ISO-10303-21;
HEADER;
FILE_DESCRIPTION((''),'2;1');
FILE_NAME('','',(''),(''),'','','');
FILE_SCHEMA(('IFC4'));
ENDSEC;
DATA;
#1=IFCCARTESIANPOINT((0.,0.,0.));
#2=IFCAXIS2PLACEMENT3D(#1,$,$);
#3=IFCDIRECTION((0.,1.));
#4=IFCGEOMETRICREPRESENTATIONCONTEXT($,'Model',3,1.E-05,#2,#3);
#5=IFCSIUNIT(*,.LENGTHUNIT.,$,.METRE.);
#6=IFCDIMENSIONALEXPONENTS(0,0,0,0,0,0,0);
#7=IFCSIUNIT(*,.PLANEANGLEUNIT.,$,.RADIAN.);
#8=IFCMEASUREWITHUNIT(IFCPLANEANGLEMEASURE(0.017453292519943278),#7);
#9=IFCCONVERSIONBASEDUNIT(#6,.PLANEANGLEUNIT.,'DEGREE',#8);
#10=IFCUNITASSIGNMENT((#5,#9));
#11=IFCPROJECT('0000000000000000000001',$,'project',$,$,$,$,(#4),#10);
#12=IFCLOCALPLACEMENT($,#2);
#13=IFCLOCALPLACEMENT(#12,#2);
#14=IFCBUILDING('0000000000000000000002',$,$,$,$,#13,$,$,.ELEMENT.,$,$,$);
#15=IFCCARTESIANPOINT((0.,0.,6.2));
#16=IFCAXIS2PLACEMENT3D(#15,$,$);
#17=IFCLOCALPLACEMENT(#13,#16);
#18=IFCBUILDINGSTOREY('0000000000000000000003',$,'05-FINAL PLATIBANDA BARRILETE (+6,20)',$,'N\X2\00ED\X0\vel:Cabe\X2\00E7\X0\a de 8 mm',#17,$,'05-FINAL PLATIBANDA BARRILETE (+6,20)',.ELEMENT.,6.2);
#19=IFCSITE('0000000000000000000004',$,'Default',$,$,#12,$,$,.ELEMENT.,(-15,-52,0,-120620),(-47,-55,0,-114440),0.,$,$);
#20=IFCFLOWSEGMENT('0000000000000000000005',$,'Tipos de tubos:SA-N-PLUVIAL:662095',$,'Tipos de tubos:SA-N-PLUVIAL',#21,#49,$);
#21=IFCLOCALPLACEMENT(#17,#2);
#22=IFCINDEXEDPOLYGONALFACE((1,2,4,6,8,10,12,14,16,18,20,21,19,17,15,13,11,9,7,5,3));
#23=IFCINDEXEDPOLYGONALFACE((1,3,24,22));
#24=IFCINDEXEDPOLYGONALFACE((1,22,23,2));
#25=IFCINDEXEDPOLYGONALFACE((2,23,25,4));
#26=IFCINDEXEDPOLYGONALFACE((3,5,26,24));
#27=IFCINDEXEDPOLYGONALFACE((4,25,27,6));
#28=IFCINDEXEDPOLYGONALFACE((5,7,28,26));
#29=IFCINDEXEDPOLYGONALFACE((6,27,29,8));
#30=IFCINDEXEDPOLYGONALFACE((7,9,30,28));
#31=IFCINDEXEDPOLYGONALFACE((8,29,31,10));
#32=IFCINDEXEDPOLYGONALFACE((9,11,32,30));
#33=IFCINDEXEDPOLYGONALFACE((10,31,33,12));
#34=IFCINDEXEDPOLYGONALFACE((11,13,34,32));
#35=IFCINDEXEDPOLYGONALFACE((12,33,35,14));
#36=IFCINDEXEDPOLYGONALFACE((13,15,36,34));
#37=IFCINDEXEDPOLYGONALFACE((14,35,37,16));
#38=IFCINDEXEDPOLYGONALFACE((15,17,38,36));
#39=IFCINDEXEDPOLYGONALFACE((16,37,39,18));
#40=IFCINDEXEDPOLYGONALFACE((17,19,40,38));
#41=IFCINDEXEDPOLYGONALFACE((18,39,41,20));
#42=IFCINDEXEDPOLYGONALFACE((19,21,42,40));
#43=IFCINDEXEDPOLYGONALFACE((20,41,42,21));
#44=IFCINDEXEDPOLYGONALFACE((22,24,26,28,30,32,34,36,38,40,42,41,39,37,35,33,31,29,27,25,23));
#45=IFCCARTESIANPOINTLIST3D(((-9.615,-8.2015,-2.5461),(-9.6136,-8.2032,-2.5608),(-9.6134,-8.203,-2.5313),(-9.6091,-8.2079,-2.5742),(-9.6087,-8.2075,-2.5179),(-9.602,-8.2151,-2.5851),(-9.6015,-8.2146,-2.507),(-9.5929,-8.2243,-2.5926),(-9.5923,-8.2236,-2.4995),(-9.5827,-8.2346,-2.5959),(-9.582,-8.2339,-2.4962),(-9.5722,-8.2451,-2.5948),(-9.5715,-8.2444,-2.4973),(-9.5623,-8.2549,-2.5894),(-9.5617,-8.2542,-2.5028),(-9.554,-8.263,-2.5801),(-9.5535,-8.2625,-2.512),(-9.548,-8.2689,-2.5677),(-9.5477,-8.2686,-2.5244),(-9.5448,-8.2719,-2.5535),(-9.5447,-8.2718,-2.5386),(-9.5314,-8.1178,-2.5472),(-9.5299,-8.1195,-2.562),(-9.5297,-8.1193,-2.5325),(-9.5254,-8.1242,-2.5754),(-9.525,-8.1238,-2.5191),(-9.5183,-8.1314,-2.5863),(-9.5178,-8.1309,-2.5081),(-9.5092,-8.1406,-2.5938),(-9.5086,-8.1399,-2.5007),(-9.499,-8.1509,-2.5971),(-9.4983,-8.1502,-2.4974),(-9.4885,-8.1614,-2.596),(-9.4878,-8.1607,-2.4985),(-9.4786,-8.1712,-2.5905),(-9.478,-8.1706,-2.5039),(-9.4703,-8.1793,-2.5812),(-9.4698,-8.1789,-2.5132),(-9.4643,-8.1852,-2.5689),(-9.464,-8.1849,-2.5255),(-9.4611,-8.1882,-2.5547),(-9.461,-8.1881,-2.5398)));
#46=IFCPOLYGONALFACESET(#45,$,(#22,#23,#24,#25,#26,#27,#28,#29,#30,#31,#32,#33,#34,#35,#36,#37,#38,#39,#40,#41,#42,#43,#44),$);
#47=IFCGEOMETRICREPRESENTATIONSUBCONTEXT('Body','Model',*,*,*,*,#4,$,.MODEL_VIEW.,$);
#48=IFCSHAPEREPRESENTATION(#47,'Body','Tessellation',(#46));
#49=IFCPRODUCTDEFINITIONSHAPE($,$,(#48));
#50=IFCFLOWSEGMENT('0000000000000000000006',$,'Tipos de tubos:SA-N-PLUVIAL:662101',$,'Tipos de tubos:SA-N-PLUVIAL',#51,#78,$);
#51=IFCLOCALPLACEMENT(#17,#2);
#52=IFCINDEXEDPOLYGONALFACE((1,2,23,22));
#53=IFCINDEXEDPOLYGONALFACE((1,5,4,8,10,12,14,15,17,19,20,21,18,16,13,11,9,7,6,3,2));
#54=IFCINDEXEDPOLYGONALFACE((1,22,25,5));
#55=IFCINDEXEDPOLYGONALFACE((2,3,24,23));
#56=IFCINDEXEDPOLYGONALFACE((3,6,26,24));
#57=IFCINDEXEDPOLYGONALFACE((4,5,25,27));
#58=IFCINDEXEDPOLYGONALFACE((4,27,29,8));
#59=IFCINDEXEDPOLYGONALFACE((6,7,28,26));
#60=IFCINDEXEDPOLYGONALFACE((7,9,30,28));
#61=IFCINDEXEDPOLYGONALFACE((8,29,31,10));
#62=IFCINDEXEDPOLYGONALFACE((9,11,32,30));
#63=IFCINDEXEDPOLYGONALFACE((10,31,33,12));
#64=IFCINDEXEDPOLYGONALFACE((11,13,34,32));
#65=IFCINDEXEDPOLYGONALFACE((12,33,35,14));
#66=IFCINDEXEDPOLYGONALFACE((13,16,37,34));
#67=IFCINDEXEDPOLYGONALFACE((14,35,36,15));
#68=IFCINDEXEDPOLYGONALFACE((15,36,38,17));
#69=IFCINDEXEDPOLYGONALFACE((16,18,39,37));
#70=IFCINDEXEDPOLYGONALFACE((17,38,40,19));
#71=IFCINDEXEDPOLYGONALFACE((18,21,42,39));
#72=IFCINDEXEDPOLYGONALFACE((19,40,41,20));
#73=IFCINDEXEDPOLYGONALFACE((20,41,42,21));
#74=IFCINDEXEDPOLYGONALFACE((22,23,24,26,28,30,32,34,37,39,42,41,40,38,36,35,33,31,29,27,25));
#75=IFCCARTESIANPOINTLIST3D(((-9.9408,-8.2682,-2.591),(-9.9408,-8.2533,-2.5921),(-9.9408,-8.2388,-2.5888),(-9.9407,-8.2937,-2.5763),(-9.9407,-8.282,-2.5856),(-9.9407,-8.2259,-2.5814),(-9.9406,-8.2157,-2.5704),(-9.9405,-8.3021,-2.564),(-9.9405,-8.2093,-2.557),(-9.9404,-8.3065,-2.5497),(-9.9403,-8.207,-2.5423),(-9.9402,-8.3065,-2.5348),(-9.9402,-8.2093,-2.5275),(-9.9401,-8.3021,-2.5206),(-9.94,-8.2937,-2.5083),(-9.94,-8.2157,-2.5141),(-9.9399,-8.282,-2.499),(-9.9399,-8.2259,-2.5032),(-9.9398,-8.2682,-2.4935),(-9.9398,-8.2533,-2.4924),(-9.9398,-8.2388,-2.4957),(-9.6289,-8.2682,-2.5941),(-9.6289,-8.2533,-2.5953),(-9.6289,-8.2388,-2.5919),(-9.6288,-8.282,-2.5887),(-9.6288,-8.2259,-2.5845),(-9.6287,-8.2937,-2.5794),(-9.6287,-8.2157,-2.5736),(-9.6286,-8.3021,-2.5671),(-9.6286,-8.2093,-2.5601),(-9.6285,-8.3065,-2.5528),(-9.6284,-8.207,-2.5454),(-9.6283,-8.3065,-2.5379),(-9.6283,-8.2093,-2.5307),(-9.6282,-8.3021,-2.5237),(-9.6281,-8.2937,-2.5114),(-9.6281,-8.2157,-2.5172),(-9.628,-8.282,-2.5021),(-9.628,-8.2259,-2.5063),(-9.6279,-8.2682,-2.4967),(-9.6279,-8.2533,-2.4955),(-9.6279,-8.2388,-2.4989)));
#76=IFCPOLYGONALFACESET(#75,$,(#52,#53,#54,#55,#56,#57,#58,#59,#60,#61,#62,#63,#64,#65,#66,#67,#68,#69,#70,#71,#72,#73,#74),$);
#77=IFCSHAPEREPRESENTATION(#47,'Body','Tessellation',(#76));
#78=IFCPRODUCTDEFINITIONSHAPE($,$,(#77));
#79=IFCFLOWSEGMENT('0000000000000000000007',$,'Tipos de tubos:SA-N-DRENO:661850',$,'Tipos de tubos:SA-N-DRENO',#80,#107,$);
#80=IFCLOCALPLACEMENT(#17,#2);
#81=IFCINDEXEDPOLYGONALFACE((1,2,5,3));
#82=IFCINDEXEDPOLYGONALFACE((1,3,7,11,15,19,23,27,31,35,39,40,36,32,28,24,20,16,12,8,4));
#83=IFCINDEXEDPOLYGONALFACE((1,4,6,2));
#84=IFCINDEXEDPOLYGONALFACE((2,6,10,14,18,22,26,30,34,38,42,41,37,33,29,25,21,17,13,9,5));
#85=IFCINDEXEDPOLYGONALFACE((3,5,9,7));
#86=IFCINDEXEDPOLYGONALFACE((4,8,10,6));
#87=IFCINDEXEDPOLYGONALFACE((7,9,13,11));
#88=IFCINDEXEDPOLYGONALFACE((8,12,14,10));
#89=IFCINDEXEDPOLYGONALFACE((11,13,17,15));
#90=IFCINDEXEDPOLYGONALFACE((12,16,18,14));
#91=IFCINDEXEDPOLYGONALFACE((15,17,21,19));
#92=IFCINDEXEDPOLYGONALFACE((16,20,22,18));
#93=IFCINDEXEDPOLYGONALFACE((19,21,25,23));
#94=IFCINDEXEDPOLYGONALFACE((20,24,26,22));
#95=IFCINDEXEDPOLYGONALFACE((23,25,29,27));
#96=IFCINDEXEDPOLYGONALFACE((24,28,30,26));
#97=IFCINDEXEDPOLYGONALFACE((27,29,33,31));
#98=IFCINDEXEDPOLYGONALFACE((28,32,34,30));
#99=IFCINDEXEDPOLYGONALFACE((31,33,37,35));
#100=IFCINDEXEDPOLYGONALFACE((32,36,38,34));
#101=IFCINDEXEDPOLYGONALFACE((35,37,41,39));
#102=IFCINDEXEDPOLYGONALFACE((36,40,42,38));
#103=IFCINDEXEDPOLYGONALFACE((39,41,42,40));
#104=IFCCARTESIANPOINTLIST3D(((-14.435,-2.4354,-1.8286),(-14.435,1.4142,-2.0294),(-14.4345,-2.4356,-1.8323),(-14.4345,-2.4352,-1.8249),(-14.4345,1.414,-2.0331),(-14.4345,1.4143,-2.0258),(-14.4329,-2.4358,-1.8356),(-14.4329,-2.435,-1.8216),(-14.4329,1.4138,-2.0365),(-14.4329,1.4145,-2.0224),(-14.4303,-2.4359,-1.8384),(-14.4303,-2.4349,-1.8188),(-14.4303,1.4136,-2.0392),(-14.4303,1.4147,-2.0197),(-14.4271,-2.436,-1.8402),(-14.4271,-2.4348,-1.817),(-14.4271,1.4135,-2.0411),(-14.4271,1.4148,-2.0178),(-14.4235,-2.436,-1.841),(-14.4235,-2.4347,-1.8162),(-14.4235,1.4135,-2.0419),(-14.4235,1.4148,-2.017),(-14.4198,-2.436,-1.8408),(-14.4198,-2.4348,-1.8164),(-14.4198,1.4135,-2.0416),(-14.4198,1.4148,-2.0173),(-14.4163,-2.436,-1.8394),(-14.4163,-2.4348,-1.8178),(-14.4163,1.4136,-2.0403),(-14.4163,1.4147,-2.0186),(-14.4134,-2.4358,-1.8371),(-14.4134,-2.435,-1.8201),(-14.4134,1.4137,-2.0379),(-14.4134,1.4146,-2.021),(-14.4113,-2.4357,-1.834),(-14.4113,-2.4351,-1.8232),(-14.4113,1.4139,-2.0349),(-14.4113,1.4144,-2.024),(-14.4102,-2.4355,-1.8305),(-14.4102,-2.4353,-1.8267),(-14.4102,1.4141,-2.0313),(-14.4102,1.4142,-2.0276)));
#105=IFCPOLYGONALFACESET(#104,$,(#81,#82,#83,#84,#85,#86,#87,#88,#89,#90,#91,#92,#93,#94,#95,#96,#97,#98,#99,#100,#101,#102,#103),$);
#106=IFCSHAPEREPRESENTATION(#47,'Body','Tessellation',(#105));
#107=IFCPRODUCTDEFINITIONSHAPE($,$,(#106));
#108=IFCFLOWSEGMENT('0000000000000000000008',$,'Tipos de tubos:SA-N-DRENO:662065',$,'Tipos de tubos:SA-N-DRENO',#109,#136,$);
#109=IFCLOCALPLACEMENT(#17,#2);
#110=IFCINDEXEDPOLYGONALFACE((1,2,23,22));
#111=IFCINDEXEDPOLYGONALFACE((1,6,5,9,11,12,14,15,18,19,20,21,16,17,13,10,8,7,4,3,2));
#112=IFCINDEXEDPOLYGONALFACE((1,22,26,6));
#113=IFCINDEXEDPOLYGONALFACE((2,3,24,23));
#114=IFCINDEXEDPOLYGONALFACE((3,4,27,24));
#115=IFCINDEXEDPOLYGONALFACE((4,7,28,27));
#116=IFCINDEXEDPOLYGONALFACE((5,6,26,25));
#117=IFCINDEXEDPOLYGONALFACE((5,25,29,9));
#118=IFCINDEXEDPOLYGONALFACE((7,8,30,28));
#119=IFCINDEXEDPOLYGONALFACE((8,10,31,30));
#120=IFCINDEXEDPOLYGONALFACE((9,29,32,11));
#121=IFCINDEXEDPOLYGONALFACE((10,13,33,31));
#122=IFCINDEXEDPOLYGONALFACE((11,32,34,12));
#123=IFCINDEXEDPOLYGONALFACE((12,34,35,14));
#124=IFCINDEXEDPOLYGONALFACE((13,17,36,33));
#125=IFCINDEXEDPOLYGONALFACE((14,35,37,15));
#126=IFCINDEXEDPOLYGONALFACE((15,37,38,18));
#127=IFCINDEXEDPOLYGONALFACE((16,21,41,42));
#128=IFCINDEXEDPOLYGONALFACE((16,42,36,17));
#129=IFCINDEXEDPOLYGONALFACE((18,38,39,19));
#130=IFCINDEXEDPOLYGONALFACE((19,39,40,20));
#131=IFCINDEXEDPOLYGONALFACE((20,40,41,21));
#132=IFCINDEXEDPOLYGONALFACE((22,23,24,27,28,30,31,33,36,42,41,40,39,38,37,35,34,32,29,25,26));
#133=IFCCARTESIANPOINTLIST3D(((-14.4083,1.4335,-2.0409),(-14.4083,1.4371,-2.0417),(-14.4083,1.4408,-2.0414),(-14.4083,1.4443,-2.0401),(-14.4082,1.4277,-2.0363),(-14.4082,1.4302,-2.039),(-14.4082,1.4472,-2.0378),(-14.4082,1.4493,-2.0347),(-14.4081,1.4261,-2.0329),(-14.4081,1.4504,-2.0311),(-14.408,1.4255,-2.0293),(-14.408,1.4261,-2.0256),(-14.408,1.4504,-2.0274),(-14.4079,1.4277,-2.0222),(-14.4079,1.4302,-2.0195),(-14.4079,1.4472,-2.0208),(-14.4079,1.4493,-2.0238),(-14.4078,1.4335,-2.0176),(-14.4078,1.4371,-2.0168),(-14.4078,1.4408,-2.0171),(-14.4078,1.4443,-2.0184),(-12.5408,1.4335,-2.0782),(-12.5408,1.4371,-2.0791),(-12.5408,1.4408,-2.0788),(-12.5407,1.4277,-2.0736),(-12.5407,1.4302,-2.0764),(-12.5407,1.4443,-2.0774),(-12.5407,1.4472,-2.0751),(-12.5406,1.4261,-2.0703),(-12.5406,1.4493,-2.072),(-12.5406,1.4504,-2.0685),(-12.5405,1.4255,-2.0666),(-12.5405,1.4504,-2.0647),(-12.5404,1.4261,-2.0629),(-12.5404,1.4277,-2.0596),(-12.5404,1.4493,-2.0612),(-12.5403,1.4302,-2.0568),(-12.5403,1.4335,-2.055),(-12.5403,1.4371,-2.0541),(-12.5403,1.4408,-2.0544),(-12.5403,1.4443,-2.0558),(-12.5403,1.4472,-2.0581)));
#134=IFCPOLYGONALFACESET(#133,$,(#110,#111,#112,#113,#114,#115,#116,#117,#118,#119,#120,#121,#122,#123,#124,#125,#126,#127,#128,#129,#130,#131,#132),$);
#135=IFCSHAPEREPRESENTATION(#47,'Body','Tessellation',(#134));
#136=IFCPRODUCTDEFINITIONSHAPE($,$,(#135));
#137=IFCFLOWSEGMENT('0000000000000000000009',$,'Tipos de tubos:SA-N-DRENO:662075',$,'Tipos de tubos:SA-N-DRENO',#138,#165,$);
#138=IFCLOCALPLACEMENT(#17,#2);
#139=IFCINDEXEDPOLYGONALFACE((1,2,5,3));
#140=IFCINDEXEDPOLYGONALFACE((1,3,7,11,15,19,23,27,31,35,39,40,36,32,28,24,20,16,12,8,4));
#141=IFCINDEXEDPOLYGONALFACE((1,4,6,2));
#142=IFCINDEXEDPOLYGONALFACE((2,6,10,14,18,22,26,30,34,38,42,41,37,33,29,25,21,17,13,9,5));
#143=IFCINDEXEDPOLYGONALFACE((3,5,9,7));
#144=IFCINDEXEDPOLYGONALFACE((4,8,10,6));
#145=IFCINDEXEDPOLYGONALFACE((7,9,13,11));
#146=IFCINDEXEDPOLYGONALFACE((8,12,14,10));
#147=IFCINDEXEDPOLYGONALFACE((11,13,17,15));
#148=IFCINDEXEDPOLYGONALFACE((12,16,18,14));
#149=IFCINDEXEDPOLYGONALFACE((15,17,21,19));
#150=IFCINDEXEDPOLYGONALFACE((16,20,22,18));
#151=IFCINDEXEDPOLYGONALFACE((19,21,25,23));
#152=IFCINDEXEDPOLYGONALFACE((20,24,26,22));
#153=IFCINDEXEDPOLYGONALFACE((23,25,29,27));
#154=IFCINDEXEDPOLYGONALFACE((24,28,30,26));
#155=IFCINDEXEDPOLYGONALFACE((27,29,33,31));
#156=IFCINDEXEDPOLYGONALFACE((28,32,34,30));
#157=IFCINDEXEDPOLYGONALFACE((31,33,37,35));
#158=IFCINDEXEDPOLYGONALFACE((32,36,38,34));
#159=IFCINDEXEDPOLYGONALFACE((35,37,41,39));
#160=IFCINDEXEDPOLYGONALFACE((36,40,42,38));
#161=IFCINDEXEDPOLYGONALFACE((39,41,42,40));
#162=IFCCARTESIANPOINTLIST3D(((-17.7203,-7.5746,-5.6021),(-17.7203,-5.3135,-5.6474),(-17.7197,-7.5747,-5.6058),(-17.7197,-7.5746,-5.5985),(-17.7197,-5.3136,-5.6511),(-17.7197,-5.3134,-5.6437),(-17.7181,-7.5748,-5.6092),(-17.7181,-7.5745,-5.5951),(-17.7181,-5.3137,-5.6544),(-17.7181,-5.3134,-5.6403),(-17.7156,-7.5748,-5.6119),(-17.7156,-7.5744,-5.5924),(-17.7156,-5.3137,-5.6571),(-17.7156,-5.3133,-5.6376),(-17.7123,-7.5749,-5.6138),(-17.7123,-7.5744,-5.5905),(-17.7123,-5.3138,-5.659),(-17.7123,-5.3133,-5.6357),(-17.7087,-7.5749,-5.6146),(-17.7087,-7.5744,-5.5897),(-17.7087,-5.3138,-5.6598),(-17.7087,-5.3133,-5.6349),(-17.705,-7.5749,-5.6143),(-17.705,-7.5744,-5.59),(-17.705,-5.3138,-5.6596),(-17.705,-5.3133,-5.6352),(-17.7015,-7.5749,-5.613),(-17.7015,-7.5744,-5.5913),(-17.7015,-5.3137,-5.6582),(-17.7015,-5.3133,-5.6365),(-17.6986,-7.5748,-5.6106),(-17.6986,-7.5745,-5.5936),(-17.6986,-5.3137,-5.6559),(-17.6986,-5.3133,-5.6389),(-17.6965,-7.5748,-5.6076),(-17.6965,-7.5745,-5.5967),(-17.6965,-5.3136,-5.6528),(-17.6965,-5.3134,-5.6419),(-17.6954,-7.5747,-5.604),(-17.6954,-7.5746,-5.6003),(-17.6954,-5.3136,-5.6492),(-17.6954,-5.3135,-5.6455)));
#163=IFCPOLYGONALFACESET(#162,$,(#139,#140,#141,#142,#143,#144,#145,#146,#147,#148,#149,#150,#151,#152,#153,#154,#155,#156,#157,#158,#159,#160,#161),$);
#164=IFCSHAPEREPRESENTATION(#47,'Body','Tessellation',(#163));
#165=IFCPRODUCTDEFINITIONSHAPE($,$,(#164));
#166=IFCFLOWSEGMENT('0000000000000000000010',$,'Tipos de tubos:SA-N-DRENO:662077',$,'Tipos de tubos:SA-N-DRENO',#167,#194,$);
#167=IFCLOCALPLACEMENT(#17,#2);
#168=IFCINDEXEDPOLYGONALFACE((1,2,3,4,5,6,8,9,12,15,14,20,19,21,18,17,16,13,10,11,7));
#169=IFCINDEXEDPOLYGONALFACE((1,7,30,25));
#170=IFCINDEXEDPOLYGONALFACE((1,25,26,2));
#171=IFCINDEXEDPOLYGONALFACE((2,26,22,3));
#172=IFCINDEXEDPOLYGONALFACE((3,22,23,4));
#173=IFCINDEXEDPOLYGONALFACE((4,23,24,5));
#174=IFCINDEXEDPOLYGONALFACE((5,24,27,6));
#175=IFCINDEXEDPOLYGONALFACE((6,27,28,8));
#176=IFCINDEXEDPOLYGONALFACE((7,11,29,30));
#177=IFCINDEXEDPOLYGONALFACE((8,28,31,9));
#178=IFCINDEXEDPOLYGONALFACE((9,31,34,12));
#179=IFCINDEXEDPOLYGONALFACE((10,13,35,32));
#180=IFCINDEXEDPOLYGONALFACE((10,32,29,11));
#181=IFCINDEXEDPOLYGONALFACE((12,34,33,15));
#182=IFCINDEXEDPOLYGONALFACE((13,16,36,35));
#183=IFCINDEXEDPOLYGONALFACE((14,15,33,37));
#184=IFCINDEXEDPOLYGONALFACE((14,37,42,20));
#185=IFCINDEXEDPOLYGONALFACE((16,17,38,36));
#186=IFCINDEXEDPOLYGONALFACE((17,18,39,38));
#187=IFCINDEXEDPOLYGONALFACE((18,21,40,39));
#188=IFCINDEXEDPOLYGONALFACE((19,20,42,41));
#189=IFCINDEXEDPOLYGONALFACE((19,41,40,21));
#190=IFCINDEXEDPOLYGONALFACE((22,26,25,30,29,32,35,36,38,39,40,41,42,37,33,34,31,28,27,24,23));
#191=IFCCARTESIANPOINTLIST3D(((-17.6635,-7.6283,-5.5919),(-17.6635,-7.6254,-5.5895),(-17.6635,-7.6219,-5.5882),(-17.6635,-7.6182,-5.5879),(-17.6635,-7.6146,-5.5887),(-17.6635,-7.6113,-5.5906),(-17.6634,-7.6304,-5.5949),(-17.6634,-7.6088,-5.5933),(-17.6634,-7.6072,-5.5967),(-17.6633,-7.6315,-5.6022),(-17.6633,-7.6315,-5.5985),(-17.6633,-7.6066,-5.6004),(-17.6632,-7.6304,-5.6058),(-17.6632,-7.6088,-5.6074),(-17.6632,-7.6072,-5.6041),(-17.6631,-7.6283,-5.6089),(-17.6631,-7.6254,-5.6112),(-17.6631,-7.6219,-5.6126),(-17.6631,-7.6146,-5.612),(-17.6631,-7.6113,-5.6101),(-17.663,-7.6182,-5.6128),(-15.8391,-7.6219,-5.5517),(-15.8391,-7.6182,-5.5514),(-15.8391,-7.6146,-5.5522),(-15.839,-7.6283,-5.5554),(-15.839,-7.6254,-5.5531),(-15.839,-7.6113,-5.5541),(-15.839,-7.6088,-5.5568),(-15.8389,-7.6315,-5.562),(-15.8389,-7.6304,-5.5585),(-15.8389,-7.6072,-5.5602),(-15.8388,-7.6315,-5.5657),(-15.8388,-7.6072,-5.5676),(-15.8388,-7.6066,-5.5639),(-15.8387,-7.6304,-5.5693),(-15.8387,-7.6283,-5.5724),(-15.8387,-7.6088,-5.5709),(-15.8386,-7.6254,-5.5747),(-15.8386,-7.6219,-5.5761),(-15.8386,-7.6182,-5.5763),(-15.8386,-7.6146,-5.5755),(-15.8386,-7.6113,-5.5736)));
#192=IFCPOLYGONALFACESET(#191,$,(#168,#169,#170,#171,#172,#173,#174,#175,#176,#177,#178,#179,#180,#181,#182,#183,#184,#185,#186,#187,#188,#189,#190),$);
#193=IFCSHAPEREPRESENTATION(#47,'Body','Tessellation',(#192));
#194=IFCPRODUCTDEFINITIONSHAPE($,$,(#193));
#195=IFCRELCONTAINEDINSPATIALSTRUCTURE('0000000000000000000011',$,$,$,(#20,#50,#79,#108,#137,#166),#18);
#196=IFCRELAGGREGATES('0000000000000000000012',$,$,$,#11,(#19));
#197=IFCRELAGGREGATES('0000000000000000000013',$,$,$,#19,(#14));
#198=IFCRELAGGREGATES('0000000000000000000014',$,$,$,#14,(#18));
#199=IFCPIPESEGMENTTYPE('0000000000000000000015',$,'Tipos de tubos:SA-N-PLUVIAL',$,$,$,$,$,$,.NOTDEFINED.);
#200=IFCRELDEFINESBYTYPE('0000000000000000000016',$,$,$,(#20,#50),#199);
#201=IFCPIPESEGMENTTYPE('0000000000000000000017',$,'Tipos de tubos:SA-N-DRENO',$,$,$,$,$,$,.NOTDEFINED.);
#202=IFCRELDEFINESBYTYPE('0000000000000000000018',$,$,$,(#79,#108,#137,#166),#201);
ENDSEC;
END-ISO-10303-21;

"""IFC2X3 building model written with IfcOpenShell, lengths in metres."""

from ifc_helpers import new_model, entity, si_unit, converted_unit, direction, frame, origin, origin_2d_with_axis, place, context, subcontext, project, spatial, circle, extrude, type_object, element, save


model = new_model("IFC2X3")

# Units and contexts
model_context = context("Model", 3, precision=1e-05, world=origin(), true_north=direction((0.0, 1.0)))
body_context = subcontext(model_context, "Body", "Model", "MODEL_VIEW")
ifc_project = project(units=[si_unit("LENGTHUNIT", "METRE"), converted_unit("PLANEANGLEUNIT", "DEGREE", entity("IfcPlaneAngleMeasure", 0.017453292519943278), si_unit("PLANEANGLEUNIT", "RADIAN"), dimensions=[0, 0, 0, 0, 0, 0, 0])], contexts=[model_context])

# Site, building, storey
site_placement = place(None, origin())
site = spatial("IfcSite", under=ifc_project, at=site_placement, Name="Default", CompositionType="ELEMENT", RefLatitude=(-15, -52, 0, -120620), RefLongitude=(-47, -55, 0, -114440), RefElevation=0.0)
building_placement = place(site_placement, origin())
building = spatial("IfcBuilding", under=site, at=building_placement, CompositionType="ELEMENT")
storey_placement = place(building_placement, frame((0.0, 0.0, 6.2)))
storey = spatial("IfcBuildingStorey", under=building, at=storey_placement, Name="05-FINAL PLATIBANDA BARRILETE (+6,20)", ObjectType="Nível:Cabeça de 8 mm", LongName="05-FINAL PLATIBANDA BARRILETE (+6,20)", CompositionType="ELEMENT", Elevation=6.2)

# Flow segments
pipe_segment_type_1 = type_object("IfcPipeSegmentType", Name="Tipos de tubos:SA-N-PLUVIAL", PredefinedType="NOTDEFINED")
flow_segment_1_placement = place(storey_placement, origin())
element("IfcFlowSegment", 1, at=flow_segment_1_placement, inside=storey, type_object=pipe_segment_type_1, Name="Tipos de tubos:SA-N-PLUVIAL:662095", ObjectType="Tipos de tubos:SA-N-PLUVIAL", context=body_context, shape_type="SweptSolid", body=[
    extrude(circle(Radius=0.05, at=origin_2d_with_axis()), frame((-9.5797, -8.2369, -2.5461), z_axis=(0.707071, 0.707072, -0.01), x_axis=(-0.707107, 0.707106, 0.0)), (0.0, 0.0, 1.0), 0.1184),
])
flow_segment_2_placement = place(storey_placement, origin())
element("IfcFlowSegment", 2, at=flow_segment_2_placement, inside=storey, type_object=pipe_segment_type_1, Name="Tipos de tubos:SA-N-PLUVIAL:662101", ObjectType="Tipos de tubos:SA-N-PLUVIAL", context=body_context, shape_type="SweptSolid", body=[
    extrude(circle(Radius=0.05, at=origin_2d_with_axis()), frame((-9.9403, -8.257, -2.5423), z_axis=(0.99995, 0.000001, -0.01), x_axis=(-0.000001, 1.0, 0.0)), (0.0, 0.0, 1.0), 0.3119),
])
pipe_segment_type_2 = type_object("IfcPipeSegmentType", Name="Tipos de tubos:SA-N-DRENO", PredefinedType="NOTDEFINED")
flow_segment_3_placement = place(storey_placement, origin())
element("IfcFlowSegment", 3, at=flow_segment_3_placement, inside=storey, type_object=pipe_segment_type_2, Name="Tipos de tubos:SA-N-DRENO:661850", ObjectType="Tipos de tubos:SA-N-DRENO", context=body_context, shape_type="SweptSolid", body=[
    extrude(circle(Radius=0.0125, at=origin_2d_with_axis()), frame((-14.4225, 1.4142, -2.0294), z_axis=(0.000001, -0.998642, 0.052103), x_axis=(-1.0, -0.000001, 0.0)), (0.0, 0.0, 1.0), 3.8548),
])
flow_segment_4_placement = place(storey_placement, origin())
element("IfcFlowSegment", 4, at=flow_segment_4_placement, inside=storey, type_object=pipe_segment_type_2, Name="Tipos de tubos:SA-N-DRENO:662065", ObjectType="Tipos de tubos:SA-N-DRENO", context=body_context, shape_type="SweptSolid", body=[
    extrude(circle(Radius=0.0125, at=origin_2d_with_axis()), frame((-14.408, 1.438, -2.0293), z_axis=(0.9998, 0.000001, -0.019986), x_axis=(0.000001, -1.0, 0.0)), (0.0, 0.0, 1.0), 1.8679),
])
flow_segment_5_placement = place(storey_placement, origin())
element("IfcFlowSegment", 5, at=flow_segment_5_placement, inside=storey, type_object=pipe_segment_type_2, Name="Tipos de tubos:SA-N-DRENO:662075", ObjectType="Tipos de tubos:SA-N-DRENO", context=body_context, shape_type="SweptSolid", body=[
    extrude(circle(Radius=0.0125, at=origin_2d_with_axis()), frame((-17.7078, -7.5746, -5.6021), z_axis=(-0.000001, 0.9998, -0.019996), x_axis=(-1.0, -0.000001, 0.0)), (0.0, 0.0, 1.0), 2.2616),
])
flow_segment_6_placement = place(storey_placement, origin())
element("IfcFlowSegment", 6, at=flow_segment_6_placement, inside=storey, type_object=pipe_segment_type_2, Name="Tipos de tubos:SA-N-DRENO:662077", ObjectType="Tipos de tubos:SA-N-DRENO", context=body_context, shape_type="SweptSolid", body=[
    extrude(circle(Radius=0.0125, at=origin_2d_with_axis()), frame((-17.6633, -7.6191, -5.6004), z_axis=(0.9998, 0.000001, 0.019996), x_axis=(-0.000001, 1.0, 0.0)), (0.0, 0.0, 1.0), 1.8248),
])

save(model, "model.ifc")
